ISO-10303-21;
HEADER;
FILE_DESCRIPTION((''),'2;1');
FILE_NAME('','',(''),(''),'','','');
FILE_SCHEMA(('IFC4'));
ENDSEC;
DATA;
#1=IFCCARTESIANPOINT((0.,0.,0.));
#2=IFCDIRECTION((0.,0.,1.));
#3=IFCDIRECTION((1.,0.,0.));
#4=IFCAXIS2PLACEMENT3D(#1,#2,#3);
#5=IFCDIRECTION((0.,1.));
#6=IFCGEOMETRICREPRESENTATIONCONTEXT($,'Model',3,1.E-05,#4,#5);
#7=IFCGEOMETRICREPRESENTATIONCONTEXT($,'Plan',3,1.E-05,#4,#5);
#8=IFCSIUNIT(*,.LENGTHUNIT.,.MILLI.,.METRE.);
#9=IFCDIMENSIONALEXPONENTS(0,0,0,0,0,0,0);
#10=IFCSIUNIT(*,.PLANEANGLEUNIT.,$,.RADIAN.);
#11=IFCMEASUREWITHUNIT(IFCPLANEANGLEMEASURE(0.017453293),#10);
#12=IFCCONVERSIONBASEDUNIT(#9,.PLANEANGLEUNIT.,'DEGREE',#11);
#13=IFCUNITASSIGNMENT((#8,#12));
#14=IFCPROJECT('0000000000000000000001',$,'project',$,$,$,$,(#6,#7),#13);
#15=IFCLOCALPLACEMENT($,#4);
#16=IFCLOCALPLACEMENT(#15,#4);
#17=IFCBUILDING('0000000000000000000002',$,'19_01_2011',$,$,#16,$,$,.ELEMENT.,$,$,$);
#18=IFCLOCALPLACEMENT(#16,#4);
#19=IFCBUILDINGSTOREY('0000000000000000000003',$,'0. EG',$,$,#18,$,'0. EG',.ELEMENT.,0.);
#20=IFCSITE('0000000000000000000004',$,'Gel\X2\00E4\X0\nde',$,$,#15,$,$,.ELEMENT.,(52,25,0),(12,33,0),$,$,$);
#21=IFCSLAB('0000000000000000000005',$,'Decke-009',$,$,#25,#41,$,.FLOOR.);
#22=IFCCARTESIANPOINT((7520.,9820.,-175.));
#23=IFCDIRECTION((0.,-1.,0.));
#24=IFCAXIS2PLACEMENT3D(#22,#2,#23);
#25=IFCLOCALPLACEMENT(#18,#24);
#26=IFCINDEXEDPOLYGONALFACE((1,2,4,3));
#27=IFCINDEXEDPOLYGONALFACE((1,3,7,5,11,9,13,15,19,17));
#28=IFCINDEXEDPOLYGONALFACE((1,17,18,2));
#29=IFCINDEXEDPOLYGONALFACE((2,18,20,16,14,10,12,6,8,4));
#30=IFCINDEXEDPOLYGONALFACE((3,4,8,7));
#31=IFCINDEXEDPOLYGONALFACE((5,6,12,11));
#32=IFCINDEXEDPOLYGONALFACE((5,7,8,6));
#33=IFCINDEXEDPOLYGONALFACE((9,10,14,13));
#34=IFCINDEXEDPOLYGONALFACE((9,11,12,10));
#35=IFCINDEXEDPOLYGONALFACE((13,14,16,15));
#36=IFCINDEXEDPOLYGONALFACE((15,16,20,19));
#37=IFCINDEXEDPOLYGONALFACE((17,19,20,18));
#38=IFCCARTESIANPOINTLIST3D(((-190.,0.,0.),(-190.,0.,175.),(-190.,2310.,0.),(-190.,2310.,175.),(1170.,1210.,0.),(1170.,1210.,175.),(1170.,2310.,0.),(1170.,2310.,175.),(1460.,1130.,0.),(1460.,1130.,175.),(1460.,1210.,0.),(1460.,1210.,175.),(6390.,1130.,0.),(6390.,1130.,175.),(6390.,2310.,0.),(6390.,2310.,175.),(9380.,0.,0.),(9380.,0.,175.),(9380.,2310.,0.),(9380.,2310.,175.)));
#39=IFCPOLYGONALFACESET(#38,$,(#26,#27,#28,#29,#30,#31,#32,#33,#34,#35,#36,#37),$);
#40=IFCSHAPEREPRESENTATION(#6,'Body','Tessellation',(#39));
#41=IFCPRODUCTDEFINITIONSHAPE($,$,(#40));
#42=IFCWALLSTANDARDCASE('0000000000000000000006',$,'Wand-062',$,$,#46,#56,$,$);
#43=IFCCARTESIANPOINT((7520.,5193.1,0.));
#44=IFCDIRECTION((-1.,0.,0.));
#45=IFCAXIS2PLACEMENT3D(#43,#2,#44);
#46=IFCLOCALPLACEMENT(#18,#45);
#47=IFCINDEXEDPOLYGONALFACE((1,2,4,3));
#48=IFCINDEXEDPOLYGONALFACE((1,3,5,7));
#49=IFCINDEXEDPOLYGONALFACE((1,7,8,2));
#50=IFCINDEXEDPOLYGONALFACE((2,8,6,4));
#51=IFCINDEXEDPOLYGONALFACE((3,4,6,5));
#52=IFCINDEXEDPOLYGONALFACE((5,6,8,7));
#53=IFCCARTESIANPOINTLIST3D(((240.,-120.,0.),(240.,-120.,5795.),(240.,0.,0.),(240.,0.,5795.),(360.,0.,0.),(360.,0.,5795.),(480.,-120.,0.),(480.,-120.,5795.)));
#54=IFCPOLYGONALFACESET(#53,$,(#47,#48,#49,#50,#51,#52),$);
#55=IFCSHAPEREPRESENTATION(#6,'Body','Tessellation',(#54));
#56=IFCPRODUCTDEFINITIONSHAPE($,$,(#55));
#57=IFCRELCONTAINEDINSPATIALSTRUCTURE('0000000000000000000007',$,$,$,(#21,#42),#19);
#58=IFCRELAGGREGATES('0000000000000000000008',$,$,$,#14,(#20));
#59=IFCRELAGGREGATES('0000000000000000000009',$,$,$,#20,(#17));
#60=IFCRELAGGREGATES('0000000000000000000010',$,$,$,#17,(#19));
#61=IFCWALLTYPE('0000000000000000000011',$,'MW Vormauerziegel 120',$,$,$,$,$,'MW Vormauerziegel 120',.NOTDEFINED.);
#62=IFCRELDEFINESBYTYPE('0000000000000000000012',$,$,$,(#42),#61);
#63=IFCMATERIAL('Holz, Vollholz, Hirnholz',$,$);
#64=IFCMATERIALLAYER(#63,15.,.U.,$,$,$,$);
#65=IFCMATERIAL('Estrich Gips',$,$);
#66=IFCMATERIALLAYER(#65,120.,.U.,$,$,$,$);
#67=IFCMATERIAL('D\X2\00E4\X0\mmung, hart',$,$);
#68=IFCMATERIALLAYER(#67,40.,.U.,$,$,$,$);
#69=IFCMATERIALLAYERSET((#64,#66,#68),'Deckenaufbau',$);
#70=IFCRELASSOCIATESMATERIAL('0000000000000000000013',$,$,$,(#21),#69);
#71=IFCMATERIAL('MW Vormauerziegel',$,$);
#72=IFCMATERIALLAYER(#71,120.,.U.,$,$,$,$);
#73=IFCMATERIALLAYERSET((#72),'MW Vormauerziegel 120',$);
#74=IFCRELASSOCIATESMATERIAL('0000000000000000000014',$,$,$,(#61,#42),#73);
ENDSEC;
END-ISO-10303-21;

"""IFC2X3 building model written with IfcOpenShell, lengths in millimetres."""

from ifc_helpers import new_model, entity, si_unit, converted_unit, direction, frame, origin_with_axes, place, context, project, spatial, polyline, outline, extrude, material, layer, layer_set, layer_usage, type_object, element, save


model = new_model("IFC2X3")

# Units and contexts
model_context = context("Model", 3, precision=1e-05, world=origin_with_axes(), true_north=direction((0.0, 1.0)))
plan_context = context("Plan", 3, precision=1e-05, world=origin_with_axes(), true_north=direction((0.0, 1.0)))
ifc_project = project(units=[si_unit("LENGTHUNIT", "METRE", prefix="MILLI"), converted_unit("PLANEANGLEUNIT", "DEGREE", entity("IfcPlaneAngleMeasure", 0.017453293), si_unit("PLANEANGLEUNIT", "RADIAN"), dimensions=[0, 0, 0, 0, 0, 0, 0])], contexts=[model_context, plan_context])

# Site, building, storey
site_placement = place(None, origin_with_axes())
site = spatial("IfcSite", under=ifc_project, at=site_placement, Name="Gelände", CompositionType="ELEMENT", RefLatitude=(52, 25, 0), RefLongitude=(12, 33, 0))
building_placement = place(site_placement, origin_with_axes())
building = spatial("IfcBuilding", under=site, at=building_placement, Name="19_01_2011", CompositionType="ELEMENT")
storey_placement = place(building_placement, origin_with_axes())
storey = spatial("IfcBuildingStorey", under=building, at=storey_placement, Name="0. EG", LongName="0. EG", CompositionType="ELEMENT", Elevation=0.0)

# Slab
ifc_material_1 = material(Name="Holz, Vollholz, Hirnholz")
ifc_layer_1 = layer(ifc_material_1, 15.0, ventilated="UNKNOWN")
ifc_material_2 = material(Name="Estrich Gips")
ifc_layer_2 = layer(ifc_material_2, 120.0, ventilated="UNKNOWN")
ifc_material_3 = material(Name="Dämmung, hart")
ifc_layer_3 = layer(ifc_material_3, 40.0, ventilated="UNKNOWN")
ifc_layer_set_1 = layer_set([ifc_layer_1, ifc_layer_2, ifc_layer_3], Name="Deckenaufbau")
ifc_layer_usage_1 = layer_usage(ifc_layer_set_1, "AXIS3", "NEGATIVE", 175.0)
slab_1_placement = place(storey_placement, frame((7520.0, 9820.0, -175.0), z_axis=(0.0, 0.0, 1.0), x_axis=(0.0, -1.0, 0.0)))
element("IfcSlab", 1, at=slab_1_placement, inside=storey, material=ifc_layer_usage_1, Name="Decke-009", PredefinedType="FLOOR", context=model_context, shape_type="SweptSolid", body=[
    extrude(outline(polyline([(9380.0, 0.0), (9380.0, 2310.0), (6390.0, 2310.0), (6390.0, 1130.0), (1460.0, 1130.0), (1460.0, 1210.0), (1170.0, 1210.0), (1170.0, 2310.0), (-190.0, 2310.0), (-190.0, 0.0), (9380.0, 0.0)])), origin_with_axes(), (0.0, 0.0, 1.0), 175.0),
])

# Shared definitions
ifc_material_4 = material(Name="MW Vormauerziegel")

# Wall
ifc_layer_4 = layer(ifc_material_4, 120.0, ventilated="UNKNOWN")
ifc_layer_set_2 = layer_set([ifc_layer_4], Name="MW Vormauerziegel 120")
ifc_layer_usage_2 = layer_usage(ifc_layer_set_2, "AXIS2", "NEGATIVE", 0.0)
wall_type_1 = type_object("IfcWallType", Name="MW Vormauerziegel 120", ElementType="MW Vormauerziegel 120", PredefinedType="NOTDEFINED", material=ifc_layer_set_2)
wall_1_placement = place(storey_placement, frame((7520.0, 5193.1, 0.0), z_axis=(0.0, 0.0, 1.0), x_axis=(-1.0, 0.0, 0.0)))
element("IfcWallStandardCase", 2, at=wall_1_placement, inside=storey, type_object=wall_type_1, material=ifc_layer_usage_2, Name="Wand-062", context=model_context, shape_type="SweptSolid", body=[
    extrude(outline(polyline([(240.0, -120.0), (480.0, -120.0), (360.0, 0.0), (240.0, 0.0), (240.0, -120.0)])), origin_with_axes(), (0.0, 0.0, 1.0), 5795.0),
])

save(model, "model.ifc")
